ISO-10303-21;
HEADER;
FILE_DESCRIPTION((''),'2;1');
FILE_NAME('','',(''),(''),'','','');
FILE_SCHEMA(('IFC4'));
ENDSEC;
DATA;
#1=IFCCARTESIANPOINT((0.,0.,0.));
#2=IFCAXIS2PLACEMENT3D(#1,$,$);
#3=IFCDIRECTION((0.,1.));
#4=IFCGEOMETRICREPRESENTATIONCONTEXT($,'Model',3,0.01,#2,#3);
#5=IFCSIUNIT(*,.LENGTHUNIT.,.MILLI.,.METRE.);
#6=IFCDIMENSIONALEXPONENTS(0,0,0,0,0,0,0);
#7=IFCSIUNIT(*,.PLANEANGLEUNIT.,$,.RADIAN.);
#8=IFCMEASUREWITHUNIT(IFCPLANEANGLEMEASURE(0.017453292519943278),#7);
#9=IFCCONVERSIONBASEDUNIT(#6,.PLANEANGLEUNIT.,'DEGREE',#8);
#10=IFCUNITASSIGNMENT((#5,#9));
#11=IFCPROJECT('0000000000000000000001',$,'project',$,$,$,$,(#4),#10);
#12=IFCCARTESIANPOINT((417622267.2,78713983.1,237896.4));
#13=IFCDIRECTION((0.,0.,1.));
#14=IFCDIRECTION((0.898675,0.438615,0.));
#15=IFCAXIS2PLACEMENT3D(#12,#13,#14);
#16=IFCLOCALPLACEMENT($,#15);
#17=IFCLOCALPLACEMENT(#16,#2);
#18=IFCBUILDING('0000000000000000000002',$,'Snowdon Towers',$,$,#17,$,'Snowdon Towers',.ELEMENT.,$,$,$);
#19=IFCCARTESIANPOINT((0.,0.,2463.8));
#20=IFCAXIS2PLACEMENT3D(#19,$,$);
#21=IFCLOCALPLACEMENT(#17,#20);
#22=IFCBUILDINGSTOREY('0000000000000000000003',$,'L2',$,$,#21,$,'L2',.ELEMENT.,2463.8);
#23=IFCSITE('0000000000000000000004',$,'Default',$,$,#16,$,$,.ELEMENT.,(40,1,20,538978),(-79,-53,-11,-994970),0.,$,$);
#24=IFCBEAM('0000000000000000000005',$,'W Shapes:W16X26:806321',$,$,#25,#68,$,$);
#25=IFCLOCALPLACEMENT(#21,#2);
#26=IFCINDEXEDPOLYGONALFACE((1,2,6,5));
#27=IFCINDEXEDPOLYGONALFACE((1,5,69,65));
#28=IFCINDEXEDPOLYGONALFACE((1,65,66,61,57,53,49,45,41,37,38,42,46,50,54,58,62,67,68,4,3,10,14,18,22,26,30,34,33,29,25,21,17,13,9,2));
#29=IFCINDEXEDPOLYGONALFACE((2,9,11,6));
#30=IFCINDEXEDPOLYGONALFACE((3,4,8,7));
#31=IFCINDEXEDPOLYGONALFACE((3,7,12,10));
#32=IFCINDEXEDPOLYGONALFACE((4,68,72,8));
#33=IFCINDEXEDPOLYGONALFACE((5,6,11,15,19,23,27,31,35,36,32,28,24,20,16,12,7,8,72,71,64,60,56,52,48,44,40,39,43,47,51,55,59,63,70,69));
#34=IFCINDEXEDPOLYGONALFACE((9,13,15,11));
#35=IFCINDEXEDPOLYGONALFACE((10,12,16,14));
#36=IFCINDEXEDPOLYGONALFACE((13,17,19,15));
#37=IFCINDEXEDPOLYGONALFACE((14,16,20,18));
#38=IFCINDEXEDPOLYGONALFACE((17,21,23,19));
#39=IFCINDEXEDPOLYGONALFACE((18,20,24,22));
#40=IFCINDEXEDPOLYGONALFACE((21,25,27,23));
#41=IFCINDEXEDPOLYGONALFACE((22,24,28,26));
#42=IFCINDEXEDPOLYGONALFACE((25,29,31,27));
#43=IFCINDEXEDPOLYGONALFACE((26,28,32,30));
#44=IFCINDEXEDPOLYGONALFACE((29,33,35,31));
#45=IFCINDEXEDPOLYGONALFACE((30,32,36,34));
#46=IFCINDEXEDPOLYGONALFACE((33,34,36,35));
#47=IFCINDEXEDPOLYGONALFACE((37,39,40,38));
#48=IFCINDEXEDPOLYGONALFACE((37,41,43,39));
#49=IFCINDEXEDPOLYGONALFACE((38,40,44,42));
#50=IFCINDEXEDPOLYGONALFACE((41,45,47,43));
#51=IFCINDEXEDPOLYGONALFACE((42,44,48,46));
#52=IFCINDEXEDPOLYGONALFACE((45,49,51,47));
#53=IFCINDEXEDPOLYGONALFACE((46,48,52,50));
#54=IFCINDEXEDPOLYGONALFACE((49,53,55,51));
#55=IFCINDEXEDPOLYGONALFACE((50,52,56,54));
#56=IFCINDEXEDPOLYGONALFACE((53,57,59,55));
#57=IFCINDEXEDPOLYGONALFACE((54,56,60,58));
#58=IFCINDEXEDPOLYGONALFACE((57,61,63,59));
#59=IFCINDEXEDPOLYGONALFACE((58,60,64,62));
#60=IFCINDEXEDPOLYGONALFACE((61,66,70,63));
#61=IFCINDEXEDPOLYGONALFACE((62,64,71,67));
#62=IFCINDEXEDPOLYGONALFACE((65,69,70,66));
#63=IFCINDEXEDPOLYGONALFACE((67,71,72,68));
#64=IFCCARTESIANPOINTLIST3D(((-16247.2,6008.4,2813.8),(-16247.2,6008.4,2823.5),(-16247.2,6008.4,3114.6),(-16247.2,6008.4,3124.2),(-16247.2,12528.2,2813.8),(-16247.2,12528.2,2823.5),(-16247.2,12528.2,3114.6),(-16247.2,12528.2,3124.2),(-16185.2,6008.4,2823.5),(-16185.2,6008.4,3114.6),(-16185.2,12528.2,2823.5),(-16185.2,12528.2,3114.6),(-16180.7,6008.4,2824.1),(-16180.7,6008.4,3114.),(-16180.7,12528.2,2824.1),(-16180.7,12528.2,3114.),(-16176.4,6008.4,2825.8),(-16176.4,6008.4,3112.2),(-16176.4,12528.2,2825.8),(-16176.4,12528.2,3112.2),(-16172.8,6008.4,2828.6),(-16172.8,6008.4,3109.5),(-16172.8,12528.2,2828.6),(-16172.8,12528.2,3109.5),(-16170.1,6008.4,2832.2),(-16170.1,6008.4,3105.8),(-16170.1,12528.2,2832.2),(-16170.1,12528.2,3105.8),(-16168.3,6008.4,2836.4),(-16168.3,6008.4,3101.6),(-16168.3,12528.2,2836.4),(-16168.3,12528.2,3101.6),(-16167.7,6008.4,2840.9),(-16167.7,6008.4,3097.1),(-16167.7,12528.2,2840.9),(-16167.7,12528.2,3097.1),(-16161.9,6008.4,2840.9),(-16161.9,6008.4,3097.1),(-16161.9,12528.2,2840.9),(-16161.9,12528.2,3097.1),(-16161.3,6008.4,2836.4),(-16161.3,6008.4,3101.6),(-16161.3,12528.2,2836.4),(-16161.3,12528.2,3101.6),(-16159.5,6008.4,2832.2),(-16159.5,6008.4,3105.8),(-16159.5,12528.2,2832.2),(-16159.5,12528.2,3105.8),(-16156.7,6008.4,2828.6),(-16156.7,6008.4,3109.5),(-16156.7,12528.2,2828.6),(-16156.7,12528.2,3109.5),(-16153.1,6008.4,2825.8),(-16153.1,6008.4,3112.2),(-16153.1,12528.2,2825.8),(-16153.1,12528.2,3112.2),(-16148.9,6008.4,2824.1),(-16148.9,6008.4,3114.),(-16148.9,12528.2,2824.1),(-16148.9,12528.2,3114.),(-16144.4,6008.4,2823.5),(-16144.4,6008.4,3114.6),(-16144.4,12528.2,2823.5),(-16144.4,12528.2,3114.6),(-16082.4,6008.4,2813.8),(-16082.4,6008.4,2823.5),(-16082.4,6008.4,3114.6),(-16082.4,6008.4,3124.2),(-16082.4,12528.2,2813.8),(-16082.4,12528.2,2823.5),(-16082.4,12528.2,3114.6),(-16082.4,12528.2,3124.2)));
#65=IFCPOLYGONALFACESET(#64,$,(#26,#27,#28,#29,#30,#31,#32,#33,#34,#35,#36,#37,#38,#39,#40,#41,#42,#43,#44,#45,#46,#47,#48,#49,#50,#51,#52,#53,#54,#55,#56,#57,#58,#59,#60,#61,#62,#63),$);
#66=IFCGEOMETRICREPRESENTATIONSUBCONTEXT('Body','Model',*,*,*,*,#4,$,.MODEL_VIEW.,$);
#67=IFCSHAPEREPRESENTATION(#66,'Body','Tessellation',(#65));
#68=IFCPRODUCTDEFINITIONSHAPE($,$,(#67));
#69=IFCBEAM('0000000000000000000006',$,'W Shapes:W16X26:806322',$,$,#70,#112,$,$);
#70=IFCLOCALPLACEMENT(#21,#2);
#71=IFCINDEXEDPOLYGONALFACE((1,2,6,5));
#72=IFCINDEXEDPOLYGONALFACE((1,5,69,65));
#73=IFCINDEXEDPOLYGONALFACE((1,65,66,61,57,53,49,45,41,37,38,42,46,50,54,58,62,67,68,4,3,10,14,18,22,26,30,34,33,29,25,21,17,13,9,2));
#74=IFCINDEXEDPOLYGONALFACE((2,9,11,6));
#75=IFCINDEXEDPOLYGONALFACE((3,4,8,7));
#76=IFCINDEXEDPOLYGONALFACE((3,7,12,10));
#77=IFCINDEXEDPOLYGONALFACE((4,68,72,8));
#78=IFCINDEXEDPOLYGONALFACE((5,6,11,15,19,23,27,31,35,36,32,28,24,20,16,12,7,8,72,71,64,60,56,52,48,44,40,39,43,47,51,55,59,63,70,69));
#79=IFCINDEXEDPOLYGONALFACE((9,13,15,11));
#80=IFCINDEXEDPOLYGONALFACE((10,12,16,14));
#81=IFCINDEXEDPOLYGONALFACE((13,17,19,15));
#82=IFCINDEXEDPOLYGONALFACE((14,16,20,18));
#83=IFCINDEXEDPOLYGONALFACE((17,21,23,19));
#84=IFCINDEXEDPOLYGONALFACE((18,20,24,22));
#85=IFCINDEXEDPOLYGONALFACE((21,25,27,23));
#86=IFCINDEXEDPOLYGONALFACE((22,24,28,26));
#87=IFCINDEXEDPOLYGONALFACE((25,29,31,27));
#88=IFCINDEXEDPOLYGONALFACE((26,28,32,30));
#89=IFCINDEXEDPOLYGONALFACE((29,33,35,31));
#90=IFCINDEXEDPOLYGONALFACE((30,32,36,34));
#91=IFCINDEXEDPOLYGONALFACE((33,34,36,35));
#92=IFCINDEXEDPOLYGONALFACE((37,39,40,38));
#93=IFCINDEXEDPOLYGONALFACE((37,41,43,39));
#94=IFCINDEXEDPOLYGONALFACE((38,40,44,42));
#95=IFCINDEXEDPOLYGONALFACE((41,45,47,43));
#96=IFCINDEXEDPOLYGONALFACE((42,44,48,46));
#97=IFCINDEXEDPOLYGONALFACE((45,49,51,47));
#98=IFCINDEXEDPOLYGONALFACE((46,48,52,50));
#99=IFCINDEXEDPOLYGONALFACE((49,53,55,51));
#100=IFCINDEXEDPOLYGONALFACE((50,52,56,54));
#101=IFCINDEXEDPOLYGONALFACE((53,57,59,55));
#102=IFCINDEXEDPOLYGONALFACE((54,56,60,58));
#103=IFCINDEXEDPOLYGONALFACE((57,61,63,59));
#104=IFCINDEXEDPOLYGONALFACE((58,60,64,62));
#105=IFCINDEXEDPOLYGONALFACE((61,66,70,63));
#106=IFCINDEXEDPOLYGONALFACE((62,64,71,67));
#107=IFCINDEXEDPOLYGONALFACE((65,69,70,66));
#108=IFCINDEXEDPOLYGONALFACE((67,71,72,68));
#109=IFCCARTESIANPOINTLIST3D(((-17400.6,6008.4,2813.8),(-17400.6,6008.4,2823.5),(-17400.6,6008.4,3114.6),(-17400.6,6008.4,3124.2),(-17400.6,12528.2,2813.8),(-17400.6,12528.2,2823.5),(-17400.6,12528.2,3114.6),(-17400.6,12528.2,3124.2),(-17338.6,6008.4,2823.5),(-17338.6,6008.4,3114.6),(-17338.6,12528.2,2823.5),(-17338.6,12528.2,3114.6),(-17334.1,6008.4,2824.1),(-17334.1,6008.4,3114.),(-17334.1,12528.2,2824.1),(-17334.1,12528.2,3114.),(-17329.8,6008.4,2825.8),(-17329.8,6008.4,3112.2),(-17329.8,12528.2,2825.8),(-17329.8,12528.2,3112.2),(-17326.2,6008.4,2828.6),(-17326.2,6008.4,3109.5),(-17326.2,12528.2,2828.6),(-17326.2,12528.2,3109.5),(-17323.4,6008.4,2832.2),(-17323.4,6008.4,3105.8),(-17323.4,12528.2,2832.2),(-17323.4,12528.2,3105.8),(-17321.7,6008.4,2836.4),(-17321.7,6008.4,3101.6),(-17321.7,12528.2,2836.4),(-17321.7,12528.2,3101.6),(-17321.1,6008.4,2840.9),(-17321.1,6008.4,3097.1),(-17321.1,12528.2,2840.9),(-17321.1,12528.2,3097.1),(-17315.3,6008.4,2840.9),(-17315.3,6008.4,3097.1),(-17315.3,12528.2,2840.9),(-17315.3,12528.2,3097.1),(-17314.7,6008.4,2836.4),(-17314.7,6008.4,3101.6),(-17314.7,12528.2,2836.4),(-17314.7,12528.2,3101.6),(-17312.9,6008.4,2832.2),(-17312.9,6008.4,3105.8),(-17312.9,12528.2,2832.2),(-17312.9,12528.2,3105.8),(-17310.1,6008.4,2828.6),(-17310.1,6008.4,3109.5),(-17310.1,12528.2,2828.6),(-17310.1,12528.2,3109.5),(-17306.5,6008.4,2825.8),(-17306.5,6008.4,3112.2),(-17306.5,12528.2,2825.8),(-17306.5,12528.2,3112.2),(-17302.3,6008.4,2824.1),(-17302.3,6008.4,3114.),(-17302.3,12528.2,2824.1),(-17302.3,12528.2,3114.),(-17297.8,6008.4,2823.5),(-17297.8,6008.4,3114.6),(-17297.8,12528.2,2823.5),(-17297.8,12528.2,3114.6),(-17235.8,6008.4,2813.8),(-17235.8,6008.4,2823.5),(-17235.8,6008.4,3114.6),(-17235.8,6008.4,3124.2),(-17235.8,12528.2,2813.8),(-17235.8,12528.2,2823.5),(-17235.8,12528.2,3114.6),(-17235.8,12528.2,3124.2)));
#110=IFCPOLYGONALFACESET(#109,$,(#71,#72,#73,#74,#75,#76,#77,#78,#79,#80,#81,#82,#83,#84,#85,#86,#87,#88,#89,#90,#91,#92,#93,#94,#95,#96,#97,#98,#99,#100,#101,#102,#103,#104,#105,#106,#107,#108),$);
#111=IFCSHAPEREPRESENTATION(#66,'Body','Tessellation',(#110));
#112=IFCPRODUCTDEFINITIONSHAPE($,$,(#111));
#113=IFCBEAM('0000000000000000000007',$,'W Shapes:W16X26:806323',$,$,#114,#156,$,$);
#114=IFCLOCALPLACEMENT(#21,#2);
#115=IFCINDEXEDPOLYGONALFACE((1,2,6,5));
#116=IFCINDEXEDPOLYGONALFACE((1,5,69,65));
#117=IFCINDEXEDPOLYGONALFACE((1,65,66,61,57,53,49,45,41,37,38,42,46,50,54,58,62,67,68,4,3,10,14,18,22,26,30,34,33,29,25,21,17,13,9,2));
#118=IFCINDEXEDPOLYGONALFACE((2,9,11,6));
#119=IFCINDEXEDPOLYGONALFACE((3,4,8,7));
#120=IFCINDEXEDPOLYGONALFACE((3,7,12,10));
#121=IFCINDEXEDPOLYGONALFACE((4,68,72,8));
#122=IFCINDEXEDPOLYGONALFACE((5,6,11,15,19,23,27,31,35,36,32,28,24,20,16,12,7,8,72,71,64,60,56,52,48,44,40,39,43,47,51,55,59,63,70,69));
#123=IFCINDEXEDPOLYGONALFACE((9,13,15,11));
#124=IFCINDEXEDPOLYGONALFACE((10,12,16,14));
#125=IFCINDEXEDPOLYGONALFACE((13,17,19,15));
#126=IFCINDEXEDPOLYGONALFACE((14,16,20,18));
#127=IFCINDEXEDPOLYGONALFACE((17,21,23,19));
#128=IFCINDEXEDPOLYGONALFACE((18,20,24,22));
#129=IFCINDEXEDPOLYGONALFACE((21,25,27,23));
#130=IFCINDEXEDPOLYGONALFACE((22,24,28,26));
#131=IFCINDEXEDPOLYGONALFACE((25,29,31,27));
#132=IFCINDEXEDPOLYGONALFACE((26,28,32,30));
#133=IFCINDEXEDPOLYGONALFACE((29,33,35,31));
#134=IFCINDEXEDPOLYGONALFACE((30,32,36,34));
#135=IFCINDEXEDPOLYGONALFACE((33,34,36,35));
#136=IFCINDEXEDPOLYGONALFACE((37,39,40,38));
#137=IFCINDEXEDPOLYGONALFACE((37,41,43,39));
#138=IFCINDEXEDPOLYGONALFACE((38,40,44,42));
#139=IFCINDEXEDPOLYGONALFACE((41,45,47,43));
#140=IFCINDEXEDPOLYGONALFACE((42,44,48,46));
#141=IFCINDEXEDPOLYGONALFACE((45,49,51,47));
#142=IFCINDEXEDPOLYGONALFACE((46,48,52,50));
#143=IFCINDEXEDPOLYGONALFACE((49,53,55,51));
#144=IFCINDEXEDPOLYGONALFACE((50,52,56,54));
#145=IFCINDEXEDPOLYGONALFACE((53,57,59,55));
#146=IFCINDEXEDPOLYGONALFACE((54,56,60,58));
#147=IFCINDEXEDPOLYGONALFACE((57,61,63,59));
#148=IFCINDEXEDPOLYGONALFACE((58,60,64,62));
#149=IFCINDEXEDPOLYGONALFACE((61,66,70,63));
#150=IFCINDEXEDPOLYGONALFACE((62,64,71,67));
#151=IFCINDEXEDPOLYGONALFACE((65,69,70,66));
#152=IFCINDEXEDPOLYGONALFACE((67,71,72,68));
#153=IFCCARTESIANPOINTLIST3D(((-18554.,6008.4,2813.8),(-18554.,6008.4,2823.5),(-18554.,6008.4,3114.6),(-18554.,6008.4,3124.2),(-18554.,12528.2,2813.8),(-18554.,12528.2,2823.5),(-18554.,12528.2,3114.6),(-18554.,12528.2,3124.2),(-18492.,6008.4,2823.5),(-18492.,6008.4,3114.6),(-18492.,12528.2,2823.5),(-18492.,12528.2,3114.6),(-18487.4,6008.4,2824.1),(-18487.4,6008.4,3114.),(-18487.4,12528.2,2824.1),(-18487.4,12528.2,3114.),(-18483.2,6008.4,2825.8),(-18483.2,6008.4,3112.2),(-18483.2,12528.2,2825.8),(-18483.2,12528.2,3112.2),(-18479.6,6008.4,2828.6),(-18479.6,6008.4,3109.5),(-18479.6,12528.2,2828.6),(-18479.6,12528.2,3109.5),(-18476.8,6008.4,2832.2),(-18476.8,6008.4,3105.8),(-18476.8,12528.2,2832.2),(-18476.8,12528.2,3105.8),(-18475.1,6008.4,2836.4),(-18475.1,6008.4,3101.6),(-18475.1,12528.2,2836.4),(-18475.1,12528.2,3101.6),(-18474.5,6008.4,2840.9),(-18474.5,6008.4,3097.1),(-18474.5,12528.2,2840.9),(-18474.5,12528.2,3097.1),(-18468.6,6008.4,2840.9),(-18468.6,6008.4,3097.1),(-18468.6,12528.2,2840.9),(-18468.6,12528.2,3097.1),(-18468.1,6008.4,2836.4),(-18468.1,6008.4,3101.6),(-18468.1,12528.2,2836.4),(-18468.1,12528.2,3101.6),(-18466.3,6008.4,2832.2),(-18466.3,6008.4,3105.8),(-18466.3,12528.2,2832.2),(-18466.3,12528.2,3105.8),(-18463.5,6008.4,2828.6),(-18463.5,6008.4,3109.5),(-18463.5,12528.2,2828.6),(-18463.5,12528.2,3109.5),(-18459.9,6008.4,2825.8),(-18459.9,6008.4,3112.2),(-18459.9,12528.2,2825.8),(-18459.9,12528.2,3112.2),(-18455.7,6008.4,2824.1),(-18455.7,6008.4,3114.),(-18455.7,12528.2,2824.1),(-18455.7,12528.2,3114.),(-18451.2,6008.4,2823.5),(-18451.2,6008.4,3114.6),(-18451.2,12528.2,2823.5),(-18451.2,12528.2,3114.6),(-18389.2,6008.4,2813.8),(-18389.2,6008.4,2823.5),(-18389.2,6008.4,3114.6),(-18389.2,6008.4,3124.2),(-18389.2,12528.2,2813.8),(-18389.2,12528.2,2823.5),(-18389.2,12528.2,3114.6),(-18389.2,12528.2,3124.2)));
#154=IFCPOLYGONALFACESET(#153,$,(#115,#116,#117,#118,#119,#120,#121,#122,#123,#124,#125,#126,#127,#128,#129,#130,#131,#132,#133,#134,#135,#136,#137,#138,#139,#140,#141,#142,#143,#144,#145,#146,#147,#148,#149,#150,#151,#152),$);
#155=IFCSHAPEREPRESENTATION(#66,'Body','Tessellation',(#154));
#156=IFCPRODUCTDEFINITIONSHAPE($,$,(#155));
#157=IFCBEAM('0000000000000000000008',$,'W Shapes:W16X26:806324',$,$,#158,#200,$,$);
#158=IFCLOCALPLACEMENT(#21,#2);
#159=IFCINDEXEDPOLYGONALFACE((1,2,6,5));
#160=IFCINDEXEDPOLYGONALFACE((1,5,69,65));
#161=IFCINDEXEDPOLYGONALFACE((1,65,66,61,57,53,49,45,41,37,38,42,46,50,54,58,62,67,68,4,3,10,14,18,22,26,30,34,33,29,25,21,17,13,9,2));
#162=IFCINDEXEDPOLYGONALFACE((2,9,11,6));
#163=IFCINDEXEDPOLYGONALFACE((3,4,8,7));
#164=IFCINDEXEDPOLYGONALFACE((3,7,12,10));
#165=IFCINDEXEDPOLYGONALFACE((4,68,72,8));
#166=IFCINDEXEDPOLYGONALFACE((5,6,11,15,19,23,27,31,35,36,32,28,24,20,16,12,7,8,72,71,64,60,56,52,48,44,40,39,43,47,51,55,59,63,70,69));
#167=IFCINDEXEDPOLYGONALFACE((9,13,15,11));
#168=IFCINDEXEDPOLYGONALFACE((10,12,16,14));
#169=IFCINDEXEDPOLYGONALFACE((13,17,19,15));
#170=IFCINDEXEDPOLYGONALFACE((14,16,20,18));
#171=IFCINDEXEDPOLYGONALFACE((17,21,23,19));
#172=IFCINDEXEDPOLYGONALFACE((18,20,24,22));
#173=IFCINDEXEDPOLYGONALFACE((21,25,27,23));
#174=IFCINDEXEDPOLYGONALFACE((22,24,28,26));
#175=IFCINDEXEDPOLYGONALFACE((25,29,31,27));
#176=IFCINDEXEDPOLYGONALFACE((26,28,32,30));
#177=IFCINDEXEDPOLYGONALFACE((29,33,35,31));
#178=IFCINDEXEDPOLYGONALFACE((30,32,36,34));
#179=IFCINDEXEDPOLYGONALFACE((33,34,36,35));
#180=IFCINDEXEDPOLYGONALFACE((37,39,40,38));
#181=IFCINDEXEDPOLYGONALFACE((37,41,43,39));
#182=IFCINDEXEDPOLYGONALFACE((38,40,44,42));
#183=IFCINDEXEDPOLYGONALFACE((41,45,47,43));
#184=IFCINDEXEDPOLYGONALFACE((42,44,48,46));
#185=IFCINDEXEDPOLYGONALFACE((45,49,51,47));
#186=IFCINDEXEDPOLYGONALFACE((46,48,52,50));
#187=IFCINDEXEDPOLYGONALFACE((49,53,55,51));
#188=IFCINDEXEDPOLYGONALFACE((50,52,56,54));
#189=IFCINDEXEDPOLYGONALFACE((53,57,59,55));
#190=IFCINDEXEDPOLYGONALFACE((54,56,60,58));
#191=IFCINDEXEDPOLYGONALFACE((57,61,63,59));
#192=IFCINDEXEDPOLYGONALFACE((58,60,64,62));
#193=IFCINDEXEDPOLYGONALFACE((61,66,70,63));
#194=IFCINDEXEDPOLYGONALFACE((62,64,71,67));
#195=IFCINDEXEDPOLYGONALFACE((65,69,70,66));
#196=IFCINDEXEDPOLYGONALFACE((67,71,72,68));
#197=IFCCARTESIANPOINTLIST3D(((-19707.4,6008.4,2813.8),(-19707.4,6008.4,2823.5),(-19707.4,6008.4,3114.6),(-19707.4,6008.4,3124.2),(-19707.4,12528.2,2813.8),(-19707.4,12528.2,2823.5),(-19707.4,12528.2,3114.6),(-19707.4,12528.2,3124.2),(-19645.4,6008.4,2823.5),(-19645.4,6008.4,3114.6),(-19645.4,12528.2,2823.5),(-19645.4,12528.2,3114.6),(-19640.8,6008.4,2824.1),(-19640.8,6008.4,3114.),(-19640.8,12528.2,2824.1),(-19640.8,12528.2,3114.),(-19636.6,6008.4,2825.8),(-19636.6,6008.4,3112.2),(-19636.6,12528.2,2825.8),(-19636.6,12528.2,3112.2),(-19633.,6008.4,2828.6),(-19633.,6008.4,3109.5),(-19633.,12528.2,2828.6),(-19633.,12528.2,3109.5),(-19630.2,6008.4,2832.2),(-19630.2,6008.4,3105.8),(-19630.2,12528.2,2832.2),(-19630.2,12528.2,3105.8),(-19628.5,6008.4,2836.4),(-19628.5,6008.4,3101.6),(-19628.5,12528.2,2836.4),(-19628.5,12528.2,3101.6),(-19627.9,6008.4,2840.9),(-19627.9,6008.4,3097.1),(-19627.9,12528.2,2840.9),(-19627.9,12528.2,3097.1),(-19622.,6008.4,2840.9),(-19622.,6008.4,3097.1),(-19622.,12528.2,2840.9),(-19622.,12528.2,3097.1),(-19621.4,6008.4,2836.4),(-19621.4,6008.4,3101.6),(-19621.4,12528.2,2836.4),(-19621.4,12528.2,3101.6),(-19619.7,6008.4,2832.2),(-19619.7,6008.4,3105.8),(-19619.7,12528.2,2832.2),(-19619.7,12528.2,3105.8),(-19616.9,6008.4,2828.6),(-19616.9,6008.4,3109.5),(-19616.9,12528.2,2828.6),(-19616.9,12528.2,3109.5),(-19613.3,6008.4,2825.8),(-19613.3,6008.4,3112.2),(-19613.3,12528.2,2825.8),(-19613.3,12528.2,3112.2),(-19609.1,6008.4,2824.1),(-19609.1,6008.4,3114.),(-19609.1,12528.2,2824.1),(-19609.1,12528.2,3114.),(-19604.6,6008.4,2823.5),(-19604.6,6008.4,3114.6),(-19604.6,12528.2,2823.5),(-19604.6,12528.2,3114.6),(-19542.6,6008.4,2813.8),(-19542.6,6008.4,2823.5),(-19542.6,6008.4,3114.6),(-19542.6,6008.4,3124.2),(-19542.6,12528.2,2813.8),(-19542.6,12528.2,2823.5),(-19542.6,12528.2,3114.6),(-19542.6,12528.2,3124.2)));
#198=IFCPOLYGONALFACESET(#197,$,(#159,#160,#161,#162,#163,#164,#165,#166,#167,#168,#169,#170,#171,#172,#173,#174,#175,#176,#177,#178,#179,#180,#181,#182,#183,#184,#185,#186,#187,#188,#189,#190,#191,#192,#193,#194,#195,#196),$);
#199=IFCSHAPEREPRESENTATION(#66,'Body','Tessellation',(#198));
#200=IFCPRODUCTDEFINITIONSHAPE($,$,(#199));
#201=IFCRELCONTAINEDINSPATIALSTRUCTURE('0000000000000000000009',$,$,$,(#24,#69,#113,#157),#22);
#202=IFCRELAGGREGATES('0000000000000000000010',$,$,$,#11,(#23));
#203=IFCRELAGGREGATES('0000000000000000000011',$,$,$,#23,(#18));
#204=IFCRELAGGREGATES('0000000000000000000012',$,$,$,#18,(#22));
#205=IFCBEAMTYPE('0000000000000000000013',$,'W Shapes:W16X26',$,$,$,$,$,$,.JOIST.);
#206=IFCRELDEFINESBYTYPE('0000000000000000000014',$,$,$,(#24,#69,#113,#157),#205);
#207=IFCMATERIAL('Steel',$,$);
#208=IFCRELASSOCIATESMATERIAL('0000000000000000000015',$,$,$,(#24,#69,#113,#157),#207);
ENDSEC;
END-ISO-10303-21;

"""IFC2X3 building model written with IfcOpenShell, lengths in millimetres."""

from ifc_helpers import new_model, entity, si_unit, converted_unit, direction, frame, frame_2d, origin, place, context, subcontext, project, spatial, i_section, extrude, material, type_object, element, save


model = new_model("IFC2X3")

# Units and contexts
model_context = context("Model", 3, precision=0.01, world=origin(), true_north=direction((0.0, 1.0)))
body_context = subcontext(model_context, "Body", "Model", "MODEL_VIEW")
ifc_project = project(units=[si_unit("LENGTHUNIT", "METRE", prefix="MILLI"), converted_unit("PLANEANGLEUNIT", "DEGREE", entity("IfcPlaneAngleMeasure", 0.017453292519943278), si_unit("PLANEANGLEUNIT", "RADIAN"), dimensions=[0, 0, 0, 0, 0, 0, 0])], contexts=[model_context])

# Site, building, storey
site_placement = place(None, frame((417622267.2, 78713983.1, 237896.4), z_axis=(0.0, 0.0, 1.0), x_axis=(0.898675, 0.438615, 0.0)))
site = spatial("IfcSite", under=ifc_project, at=site_placement, Name="Default", CompositionType="ELEMENT", RefLatitude=(40, 1, 20, 538978), RefLongitude=(-79, -53, -11, -994970), RefElevation=0.0)
building_placement = place(site_placement, origin())
building = spatial("IfcBuilding", under=site, at=building_placement, Name="Snowdon Towers", LongName="Snowdon Towers", CompositionType="ELEMENT")
storey_placement = place(building_placement, frame((0.0, 0.0, 2463.8)))
storey = spatial("IfcBuildingStorey", under=building, at=storey_placement, Name="L2", LongName="L2", CompositionType="ELEMENT", Elevation=2463.8)

# Beams
ifc_material_1 = material(Name="Steel")
beam_type_1 = type_object("IfcBeamType", Name="W Shapes:W16X26", PredefinedType="JOIST")
beam_1_placement = place(storey_placement, frame((-16164.8, 12636.5, 3124.2), z_axis=(0.0, 0.0, 1.0), x_axis=(0.0, -1.0, 0.0)))
element("IfcBeam", 1, at=beam_1_placement, inside=storey, type_object=beam_type_1, material=ifc_material_1, Name="W Shapes:W16X26:806321", context=body_context, shape_type="SweptSolid", body=[
    extrude(i_section(OverallWidth=164.8, OverallDepth=310.4, WebThickness=5.9, FlangeThickness=9.6, FilletRadius=17.5, at=frame_2d((0.0, 0.0), x_axis=(0.0, 1.0))), frame((108.3, 0.0, -155.2), z_axis=(1.0, 0.0, 0.0), x_axis=(0.0, 0.0, -1.0)), (0.0, 0.0, 1.0), 6519.8),
])
beam_2_placement = place(storey_placement, frame((-17318.2, 12636.5, 3124.2), z_axis=(0.0, 0.0, 1.0), x_axis=(0.0, -1.0, 0.0)))
element("IfcBeam", 2, at=beam_2_placement, inside=storey, type_object=beam_type_1, material=ifc_material_1, Name="W Shapes:W16X26:806322", context=body_context, shape_type="SweptSolid", body=[
    extrude(i_section(OverallWidth=164.8, OverallDepth=310.4, WebThickness=5.9, FlangeThickness=9.6, FilletRadius=17.5, at=frame_2d((0.0, 0.0), x_axis=(0.0, 1.0))), frame((108.3, 0.0, -155.2), z_axis=(1.0, 0.0, 0.0), x_axis=(0.0, 0.0, -1.0)), (0.0, 0.0, 1.0), 6519.8),
])
beam_3_placement = place(storey_placement, frame((-18471.6, 12636.5, 3124.2), z_axis=(0.0, 0.0, 1.0), x_axis=(0.0, -1.0, 0.0)))
element("IfcBeam", 3, at=beam_3_placement, inside=storey, type_object=beam_type_1, material=ifc_material_1, Name="W Shapes:W16X26:806323", context=body_context, shape_type="SweptSolid", body=[
    extrude(i_section(OverallWidth=164.8, OverallDepth=310.4, WebThickness=5.9, FlangeThickness=9.6, FilletRadius=17.5, at=frame_2d((0.0, 0.0), x_axis=(0.0, 1.0))), frame((108.3, 0.0, -155.2), z_axis=(1.0, 0.0, 0.0), x_axis=(0.0, 0.0, -1.0)), (0.0, 0.0, 1.0), 6519.8),
])
beam_4_placement = place(storey_placement, frame((-19625.0, 12636.5, 3124.2), z_axis=(0.0, 0.0, 1.0), x_axis=(0.0, -1.0, 0.0)))
element("IfcBeam", 4, at=beam_4_placement, inside=storey, type_object=beam_type_1, material=ifc_material_1, Name="W Shapes:W16X26:806324", context=body_context, shape_type="SweptSolid", body=[
    extrude(i_section(OverallWidth=164.8, OverallDepth=310.4, WebThickness=5.9, FlangeThickness=9.6, FilletRadius=17.5, at=frame_2d((0.0, 0.0), x_axis=(0.0, 1.0))), frame((108.3, 0.0, -155.2), z_axis=(1.0, 0.0, 0.0), x_axis=(0.0, 0.0, -1.0)), (0.0, 0.0, 1.0), 6519.8),
])

save(model, "model.ifc")
